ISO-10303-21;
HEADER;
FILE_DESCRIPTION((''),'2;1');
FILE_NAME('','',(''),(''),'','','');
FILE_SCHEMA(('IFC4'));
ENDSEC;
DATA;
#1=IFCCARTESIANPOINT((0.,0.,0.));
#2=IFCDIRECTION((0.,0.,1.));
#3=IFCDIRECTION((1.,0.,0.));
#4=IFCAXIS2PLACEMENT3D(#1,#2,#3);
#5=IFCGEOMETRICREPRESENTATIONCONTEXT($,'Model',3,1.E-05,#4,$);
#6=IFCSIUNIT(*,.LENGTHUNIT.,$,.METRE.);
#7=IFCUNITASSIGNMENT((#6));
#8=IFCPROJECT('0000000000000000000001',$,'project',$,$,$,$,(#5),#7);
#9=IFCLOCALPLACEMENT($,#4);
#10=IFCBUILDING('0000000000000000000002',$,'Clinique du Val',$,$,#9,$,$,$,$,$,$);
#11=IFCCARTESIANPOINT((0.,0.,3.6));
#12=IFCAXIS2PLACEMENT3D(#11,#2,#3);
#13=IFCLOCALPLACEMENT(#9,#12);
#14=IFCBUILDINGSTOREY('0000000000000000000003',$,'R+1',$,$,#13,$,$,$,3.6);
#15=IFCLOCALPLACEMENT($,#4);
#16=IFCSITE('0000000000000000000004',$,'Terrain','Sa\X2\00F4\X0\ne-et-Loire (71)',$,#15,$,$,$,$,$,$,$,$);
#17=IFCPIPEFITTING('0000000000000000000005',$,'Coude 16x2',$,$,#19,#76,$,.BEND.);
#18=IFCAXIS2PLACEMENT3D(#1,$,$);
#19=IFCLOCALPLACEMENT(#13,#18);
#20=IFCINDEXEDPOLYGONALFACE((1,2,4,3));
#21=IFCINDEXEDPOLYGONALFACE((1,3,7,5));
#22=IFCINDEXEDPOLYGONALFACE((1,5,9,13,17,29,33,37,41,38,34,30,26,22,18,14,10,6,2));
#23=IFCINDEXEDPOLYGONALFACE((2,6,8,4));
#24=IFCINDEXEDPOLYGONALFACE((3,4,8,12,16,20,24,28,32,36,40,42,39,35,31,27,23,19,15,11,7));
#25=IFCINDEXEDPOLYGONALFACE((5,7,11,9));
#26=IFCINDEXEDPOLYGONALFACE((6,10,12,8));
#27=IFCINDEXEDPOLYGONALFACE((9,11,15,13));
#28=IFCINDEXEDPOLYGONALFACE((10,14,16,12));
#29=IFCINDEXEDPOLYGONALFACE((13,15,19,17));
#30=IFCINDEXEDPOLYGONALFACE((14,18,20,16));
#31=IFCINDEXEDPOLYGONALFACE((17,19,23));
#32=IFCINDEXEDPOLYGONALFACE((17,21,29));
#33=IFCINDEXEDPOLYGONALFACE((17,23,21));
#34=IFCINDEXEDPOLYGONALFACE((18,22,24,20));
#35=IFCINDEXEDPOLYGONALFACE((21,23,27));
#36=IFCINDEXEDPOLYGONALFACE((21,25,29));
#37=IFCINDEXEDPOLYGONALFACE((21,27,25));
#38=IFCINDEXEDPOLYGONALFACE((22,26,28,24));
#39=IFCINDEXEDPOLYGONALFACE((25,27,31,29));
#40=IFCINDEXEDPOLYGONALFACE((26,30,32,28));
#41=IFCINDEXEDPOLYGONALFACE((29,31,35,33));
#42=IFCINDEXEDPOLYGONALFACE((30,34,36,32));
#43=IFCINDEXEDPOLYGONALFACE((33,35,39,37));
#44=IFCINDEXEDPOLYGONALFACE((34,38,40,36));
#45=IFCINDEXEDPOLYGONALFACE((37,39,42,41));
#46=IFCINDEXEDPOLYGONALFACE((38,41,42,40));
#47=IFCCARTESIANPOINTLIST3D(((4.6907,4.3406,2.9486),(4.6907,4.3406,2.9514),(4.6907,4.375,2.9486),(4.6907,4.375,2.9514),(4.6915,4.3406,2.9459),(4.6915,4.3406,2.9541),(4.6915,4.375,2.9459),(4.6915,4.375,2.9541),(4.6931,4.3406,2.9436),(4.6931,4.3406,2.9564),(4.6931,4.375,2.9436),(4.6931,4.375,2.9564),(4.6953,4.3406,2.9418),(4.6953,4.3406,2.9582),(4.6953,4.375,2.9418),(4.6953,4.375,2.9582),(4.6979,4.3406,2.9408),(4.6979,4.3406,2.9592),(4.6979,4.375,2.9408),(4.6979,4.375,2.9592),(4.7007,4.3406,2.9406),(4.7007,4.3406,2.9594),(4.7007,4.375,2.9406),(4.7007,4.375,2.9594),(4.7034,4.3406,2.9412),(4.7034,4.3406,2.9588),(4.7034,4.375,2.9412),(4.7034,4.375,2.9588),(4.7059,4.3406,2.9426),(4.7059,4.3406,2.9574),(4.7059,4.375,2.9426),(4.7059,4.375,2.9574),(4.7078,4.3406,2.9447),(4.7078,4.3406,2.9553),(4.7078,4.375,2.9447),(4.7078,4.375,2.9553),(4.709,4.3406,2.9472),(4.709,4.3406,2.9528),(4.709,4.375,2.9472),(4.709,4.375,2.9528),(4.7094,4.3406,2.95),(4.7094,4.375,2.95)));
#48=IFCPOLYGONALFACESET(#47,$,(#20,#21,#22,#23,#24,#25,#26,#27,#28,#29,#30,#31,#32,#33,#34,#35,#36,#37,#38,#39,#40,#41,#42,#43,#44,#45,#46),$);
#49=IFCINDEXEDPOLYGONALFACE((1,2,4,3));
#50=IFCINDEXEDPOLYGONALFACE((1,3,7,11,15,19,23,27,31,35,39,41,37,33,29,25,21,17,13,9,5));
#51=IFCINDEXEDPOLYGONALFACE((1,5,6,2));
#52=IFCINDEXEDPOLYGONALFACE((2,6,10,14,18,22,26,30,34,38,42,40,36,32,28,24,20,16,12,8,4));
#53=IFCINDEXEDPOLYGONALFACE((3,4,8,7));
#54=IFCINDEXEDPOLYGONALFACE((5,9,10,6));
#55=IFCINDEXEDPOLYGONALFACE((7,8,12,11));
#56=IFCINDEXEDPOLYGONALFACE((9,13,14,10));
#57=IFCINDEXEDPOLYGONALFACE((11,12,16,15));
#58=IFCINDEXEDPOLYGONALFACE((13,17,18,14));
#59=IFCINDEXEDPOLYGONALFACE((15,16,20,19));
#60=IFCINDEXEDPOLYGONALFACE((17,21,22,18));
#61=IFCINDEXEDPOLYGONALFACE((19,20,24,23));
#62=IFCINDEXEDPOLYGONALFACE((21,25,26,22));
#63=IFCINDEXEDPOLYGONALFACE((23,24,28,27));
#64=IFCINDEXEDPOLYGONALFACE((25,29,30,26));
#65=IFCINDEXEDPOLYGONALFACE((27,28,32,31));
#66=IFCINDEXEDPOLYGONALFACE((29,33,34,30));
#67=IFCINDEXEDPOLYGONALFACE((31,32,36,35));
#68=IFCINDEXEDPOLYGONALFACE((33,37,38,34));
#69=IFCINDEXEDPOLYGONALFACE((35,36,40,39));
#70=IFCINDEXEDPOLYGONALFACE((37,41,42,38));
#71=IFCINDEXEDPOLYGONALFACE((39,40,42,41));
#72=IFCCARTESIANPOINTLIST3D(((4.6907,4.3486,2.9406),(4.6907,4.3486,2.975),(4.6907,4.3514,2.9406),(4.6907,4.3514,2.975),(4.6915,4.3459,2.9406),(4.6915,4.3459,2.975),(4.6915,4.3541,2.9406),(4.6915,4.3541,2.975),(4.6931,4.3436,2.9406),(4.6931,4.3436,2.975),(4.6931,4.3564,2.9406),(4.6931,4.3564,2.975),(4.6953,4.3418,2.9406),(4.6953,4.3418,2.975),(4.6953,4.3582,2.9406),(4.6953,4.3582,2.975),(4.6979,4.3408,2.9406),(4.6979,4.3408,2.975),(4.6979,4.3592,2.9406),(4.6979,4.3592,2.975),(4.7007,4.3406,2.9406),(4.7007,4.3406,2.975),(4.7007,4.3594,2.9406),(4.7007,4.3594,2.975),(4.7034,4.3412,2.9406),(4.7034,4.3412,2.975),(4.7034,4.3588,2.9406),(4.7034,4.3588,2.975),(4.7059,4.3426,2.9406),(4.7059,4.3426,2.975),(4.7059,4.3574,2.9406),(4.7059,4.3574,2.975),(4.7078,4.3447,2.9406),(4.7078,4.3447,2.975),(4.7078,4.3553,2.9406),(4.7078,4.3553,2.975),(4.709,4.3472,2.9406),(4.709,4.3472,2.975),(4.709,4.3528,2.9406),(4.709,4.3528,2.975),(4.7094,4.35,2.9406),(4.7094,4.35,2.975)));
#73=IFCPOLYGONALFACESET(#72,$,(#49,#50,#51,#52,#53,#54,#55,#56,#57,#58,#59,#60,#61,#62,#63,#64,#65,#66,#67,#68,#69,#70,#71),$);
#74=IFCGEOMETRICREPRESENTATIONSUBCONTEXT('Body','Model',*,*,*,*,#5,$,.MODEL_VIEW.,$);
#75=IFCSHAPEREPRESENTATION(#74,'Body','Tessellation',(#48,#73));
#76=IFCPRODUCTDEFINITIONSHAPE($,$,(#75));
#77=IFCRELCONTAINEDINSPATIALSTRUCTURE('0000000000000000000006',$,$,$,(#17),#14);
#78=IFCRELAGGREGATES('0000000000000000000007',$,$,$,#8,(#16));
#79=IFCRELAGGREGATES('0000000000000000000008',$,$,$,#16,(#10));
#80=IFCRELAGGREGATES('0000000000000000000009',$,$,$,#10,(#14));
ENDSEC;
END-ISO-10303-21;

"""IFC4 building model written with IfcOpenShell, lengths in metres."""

from ifc_helpers import new_model, si_unit, frame, origin_with_axes, place, context, subcontext, project, spatial, circle, extrude, element, save


model = new_model("IFC4")

# Units and contexts
model_context = context("Model", 3, precision=1e-05, world=origin_with_axes())
body_context = subcontext(model_context, "Body", "Model", "MODEL_VIEW")
ifc_project = project(units=[si_unit("LENGTHUNIT", "METRE")], contexts=[model_context])

# Site, building, storey
site_placement = place(None, origin_with_axes())
site = spatial("IfcSite", under=ifc_project, at=site_placement, Name="Terrain", Description="Saône-et-Loire (71)")
building_placement = place(None, origin_with_axes())
building = spatial("IfcBuilding", under=site, at=building_placement, Name="Clinique du Val")
storey_placement = place(building_placement, frame((0.0, 0.0, 3.6), z_axis=(0.0, 0.0, 1.0), x_axis=(1.0, 0.0, 0.0)))
storey = spatial("IfcBuildingStorey", under=building, at=storey_placement, Name="R+1", Elevation=3.6)

# Pipe fitting
for number, where, z_axis, x_axis, name in (
    (1, (4.7, 4.35, 2.95), (0.0, 0.0, 1.0), (1.0, 0.0, 0.0), "Coude 16x2"),
):
    element("IfcPipeFitting", number, at=place(storey_placement, frame(where, z_axis=z_axis, x_axis=x_axis)), inside=storey, Name=name, PredefinedType="BEND", context=body_context, shape_type="SweptSolid", body=[
        extrude(circle(Radius=0.0094), frame((0.0, -0.0094, 0.0), z_axis=(0.0, 1.0, 0.0), x_axis=(1.0, 0.0, 0.0)), (0.0, 0.0, 1.0), 0.0344),
        extrude(circle(Radius=0.0094), frame((0.0, 0.0, -0.0094), z_axis=(0.0, 0.0, 1.0), x_axis=(1.0, 0.0, 0.0)), (0.0, 0.0, 1.0), 0.0344),
    ])

save(model, "model.ifc")
